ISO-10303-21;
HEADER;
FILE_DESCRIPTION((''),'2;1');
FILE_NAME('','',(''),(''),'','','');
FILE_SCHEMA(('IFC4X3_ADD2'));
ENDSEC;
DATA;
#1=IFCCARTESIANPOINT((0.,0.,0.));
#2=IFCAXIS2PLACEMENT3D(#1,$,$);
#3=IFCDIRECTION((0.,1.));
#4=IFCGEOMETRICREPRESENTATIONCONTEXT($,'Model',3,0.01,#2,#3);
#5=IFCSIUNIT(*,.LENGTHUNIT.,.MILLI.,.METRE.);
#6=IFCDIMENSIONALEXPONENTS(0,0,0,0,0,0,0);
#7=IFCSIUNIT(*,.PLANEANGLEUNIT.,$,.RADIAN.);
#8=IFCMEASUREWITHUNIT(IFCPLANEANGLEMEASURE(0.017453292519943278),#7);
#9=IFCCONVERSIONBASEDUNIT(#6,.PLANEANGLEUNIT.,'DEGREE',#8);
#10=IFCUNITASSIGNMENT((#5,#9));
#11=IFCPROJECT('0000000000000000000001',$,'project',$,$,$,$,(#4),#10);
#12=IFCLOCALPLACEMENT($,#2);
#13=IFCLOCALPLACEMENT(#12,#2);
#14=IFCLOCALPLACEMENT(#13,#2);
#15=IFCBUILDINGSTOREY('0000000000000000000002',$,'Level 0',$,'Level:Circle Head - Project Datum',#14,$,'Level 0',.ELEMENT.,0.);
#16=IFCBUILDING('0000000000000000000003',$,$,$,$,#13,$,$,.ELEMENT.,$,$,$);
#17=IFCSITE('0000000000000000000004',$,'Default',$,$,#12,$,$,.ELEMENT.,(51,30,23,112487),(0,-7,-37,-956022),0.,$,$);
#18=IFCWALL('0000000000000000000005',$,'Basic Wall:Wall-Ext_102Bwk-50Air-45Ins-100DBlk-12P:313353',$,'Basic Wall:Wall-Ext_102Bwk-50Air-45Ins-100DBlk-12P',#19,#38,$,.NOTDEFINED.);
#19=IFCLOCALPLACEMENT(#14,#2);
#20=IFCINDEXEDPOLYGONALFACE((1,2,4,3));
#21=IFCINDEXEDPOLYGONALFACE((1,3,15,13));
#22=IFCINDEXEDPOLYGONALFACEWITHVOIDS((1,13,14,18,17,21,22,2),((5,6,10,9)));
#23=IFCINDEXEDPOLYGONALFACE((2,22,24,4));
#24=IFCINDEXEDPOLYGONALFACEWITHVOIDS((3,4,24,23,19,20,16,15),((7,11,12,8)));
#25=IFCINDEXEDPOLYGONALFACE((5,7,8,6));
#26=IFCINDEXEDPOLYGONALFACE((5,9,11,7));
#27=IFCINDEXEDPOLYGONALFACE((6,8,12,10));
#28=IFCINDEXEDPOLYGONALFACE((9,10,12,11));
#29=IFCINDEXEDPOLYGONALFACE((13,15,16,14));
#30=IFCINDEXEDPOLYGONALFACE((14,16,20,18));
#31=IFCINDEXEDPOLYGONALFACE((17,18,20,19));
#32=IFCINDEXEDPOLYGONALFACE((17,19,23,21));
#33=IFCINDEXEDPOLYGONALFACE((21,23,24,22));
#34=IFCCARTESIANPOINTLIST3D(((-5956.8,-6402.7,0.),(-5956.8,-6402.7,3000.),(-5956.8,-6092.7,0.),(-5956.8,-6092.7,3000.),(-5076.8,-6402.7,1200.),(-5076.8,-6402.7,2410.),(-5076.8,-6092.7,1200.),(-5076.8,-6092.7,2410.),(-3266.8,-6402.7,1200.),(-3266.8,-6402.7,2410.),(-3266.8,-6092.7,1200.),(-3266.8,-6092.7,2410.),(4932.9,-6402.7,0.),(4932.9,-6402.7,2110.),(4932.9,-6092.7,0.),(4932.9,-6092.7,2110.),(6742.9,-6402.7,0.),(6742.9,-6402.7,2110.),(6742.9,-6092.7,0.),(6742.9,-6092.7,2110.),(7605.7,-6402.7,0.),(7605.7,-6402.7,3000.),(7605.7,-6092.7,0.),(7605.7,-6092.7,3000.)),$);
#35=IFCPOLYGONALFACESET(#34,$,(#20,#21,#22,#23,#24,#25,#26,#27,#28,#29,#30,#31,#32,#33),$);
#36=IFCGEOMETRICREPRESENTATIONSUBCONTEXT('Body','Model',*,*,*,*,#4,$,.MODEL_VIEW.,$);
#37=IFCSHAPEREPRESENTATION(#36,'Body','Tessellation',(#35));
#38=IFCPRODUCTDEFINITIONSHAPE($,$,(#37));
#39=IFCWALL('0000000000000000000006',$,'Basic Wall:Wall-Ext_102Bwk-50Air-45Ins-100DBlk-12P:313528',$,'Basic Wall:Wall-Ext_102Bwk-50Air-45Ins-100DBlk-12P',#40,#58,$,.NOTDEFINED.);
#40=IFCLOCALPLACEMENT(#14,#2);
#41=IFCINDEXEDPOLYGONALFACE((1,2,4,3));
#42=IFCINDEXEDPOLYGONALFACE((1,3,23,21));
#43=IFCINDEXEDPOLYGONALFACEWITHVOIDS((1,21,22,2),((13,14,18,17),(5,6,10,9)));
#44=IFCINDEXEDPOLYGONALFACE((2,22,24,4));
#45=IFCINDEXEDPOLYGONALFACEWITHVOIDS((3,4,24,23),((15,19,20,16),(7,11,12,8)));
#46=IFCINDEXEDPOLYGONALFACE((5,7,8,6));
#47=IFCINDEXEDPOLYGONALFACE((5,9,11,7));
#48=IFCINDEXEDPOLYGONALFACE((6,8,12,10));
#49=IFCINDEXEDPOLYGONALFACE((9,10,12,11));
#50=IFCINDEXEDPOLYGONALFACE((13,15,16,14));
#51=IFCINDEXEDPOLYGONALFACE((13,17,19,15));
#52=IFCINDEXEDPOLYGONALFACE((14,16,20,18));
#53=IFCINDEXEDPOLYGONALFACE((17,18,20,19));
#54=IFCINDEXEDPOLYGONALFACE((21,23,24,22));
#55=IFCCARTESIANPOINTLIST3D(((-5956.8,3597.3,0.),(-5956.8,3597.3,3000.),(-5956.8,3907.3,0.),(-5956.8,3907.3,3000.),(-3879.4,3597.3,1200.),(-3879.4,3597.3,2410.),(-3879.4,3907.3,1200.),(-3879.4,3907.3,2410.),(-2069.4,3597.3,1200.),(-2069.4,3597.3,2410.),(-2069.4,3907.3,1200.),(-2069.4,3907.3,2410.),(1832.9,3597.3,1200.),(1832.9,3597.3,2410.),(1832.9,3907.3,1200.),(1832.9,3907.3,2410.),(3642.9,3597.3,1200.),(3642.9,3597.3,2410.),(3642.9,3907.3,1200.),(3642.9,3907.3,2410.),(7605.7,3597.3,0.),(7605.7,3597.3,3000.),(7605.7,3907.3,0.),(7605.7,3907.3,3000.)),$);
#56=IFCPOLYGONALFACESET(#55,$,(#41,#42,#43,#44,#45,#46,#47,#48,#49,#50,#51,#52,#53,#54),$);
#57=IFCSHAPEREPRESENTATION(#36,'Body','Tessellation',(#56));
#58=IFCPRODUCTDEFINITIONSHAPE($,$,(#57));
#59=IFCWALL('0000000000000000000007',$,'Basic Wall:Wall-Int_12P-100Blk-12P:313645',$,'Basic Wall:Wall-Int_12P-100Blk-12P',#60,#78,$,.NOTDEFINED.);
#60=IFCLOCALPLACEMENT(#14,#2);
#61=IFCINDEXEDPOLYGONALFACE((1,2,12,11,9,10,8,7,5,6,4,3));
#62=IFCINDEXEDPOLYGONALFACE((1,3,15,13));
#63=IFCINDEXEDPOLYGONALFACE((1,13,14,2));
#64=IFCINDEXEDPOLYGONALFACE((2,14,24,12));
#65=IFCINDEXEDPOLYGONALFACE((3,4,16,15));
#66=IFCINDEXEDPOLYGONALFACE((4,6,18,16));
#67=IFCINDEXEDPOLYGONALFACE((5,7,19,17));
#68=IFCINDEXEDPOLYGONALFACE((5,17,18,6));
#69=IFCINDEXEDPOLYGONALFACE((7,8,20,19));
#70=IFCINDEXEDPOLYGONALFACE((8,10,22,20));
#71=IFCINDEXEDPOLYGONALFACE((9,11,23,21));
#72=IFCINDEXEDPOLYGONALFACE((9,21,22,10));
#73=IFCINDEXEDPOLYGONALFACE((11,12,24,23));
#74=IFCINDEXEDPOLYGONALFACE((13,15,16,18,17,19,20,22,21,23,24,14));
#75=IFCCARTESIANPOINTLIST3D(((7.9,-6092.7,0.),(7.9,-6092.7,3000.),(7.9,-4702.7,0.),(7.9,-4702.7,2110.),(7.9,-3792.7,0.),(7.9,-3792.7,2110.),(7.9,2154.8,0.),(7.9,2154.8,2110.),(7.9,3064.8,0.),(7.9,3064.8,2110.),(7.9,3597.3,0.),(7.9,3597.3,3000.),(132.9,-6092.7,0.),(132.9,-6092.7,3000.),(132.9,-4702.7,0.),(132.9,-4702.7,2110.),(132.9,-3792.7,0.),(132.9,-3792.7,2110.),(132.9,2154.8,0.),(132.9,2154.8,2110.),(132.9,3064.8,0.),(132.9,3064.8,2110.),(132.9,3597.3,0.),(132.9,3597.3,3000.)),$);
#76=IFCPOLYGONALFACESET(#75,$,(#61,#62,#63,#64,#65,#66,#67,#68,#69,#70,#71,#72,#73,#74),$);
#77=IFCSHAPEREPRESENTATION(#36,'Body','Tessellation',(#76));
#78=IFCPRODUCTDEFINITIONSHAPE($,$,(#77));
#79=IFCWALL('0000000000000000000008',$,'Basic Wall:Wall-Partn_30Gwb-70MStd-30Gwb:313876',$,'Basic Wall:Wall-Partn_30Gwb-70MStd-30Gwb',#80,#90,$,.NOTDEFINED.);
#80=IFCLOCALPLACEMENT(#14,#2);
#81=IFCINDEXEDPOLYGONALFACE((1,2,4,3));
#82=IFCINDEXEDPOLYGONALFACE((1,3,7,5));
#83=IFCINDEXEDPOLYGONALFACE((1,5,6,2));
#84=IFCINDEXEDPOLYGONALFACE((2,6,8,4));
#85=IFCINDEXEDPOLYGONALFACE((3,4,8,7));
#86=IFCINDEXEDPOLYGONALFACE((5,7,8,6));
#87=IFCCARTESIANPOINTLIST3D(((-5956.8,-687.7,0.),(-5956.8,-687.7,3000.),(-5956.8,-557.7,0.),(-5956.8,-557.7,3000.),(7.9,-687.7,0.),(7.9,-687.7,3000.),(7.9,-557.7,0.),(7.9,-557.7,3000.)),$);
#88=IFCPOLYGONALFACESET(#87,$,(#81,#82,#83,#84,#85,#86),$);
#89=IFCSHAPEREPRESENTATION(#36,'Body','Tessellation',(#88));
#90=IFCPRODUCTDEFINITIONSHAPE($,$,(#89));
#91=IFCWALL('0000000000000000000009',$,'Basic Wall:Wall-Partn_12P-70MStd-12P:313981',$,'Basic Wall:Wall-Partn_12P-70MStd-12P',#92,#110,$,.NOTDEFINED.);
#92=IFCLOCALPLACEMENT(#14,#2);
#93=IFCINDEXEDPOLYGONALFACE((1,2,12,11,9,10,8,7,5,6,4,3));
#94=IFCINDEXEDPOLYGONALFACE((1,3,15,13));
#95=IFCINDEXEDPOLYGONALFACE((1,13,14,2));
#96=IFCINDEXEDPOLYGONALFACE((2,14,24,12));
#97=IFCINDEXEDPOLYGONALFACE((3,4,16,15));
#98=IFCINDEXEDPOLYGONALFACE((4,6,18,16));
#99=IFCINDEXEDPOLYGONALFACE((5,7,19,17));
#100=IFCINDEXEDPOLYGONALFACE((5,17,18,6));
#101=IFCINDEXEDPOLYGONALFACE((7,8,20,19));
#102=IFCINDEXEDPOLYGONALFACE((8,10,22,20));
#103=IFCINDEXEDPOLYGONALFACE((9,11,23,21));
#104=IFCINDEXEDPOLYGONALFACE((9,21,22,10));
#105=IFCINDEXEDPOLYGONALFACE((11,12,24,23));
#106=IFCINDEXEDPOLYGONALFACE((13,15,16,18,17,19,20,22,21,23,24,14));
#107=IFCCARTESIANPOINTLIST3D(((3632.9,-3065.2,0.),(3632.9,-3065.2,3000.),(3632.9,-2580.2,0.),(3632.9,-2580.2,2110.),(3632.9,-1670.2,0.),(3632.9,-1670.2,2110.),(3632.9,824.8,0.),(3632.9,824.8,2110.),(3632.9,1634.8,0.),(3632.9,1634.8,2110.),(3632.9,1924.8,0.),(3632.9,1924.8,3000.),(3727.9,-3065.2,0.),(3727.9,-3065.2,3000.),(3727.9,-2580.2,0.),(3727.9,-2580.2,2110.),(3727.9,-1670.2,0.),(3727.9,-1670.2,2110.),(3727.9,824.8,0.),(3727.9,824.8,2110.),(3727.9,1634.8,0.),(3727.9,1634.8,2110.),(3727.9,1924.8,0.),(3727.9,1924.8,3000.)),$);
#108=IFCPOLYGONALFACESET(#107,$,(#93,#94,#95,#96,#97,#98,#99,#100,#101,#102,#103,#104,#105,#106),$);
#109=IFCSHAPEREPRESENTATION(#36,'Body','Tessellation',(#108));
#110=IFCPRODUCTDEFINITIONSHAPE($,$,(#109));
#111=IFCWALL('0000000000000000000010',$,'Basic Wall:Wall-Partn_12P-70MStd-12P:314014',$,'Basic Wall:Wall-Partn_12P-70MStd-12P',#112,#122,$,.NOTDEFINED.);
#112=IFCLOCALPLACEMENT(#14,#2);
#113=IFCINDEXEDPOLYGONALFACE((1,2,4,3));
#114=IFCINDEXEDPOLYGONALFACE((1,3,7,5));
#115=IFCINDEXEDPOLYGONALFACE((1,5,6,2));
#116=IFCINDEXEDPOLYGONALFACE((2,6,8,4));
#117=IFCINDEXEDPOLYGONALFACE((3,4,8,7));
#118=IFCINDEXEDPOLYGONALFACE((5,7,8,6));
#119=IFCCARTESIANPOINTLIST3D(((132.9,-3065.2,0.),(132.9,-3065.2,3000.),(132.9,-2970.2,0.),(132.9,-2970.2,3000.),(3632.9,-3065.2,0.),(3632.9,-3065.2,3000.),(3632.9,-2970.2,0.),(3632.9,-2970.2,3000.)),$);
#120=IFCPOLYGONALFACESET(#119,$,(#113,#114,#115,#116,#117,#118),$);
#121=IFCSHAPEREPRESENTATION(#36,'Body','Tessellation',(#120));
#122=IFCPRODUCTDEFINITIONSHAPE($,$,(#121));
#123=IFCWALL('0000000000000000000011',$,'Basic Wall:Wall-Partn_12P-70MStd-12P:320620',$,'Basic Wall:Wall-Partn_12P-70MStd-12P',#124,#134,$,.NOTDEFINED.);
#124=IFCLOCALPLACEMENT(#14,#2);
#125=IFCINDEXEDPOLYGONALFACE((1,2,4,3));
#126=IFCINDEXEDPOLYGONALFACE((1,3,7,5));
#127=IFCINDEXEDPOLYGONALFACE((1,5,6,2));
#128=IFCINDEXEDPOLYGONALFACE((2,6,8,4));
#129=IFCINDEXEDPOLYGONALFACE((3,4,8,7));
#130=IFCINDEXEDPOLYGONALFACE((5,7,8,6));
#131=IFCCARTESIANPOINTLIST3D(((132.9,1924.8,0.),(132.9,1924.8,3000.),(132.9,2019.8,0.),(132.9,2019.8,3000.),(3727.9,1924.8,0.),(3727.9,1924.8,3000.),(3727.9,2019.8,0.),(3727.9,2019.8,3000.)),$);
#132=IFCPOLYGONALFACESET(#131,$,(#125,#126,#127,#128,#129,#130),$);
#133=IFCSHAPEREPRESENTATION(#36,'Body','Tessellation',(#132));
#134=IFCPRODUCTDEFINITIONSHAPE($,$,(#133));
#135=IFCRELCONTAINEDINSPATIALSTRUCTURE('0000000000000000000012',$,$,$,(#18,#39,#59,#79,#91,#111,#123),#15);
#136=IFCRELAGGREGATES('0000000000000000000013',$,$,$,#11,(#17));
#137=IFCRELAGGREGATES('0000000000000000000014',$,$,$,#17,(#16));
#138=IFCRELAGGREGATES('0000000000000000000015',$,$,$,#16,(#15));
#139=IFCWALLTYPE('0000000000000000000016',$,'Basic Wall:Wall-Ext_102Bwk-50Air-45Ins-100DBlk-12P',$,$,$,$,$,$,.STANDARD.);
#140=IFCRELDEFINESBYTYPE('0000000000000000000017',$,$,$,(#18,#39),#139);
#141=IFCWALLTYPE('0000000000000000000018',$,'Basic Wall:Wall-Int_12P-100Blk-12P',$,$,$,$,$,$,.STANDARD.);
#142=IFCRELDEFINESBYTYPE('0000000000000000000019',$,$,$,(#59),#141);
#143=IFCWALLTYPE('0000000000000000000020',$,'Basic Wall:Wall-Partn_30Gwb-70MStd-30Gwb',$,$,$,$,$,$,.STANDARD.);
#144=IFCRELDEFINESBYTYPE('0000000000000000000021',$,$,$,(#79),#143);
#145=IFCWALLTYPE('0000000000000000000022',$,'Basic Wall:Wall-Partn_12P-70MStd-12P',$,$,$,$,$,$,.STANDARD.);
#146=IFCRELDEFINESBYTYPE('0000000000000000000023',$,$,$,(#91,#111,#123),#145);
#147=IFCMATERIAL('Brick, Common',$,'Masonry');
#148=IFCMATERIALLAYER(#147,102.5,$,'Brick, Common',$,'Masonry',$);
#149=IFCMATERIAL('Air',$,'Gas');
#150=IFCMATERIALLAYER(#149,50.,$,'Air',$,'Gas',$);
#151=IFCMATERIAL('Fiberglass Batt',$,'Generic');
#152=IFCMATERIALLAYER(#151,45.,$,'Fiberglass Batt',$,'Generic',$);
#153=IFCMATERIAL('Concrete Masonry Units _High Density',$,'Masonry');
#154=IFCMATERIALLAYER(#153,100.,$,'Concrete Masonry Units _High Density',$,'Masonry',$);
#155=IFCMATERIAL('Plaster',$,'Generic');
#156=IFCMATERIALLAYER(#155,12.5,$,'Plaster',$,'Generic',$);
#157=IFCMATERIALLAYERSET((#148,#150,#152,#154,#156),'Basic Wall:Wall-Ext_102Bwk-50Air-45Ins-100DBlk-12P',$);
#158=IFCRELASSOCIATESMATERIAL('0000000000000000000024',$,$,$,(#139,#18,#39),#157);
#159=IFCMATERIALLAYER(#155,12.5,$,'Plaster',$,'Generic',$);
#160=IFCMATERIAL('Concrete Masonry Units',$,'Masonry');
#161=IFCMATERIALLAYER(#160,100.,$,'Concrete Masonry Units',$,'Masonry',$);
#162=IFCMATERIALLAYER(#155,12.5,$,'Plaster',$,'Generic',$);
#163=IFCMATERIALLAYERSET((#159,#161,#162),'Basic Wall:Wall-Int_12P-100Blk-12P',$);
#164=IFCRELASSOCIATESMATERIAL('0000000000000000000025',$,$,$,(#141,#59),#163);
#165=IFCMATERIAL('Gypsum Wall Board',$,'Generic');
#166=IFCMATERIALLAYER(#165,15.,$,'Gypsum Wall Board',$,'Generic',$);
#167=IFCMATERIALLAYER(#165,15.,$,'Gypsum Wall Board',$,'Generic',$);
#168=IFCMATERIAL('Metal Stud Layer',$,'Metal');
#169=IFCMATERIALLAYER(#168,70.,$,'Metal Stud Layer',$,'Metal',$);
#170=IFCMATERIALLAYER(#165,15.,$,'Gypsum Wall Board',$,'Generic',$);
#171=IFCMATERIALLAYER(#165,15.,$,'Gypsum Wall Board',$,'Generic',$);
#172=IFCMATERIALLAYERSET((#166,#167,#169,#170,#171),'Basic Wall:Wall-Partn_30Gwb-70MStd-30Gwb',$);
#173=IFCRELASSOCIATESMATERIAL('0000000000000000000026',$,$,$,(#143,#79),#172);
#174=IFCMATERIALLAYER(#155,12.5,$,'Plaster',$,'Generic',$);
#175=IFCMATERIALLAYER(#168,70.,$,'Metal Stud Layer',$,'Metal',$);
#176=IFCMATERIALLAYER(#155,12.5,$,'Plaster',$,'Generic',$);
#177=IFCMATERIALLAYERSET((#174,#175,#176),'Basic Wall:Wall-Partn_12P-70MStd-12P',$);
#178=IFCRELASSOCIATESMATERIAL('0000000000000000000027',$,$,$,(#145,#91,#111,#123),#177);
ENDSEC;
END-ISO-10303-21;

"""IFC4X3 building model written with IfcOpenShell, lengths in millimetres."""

from ifc_helpers import new_model, entity, si_unit, converted_unit, direction, frame, frame_2d, origin, place, context, subcontext, project, spatial, rectangle, extrude, material, layer, layer_set, type_object, element, save


model = new_model("IFC4X3")

# Units and contexts
model_context = context("Model", 3, precision=0.01, world=origin(), true_north=direction((0.0, 1.0)))
body_context = subcontext(model_context, "Body", "Model", "MODEL_VIEW")
ifc_project = project(units=[si_unit("LENGTHUNIT", "METRE", prefix="MILLI"), converted_unit("PLANEANGLEUNIT", "DEGREE", entity("IfcPlaneAngleMeasure", 0.017453292519943278), si_unit("PLANEANGLEUNIT", "RADIAN"), dimensions=[0, 0, 0, 0, 0, 0, 0])], contexts=[model_context])

# Site, building, storey
site_placement = place(None, origin())
site = spatial("IfcSite", under=ifc_project, at=site_placement, Name="Default", CompositionType="ELEMENT", RefLatitude=(51, 30, 23, 112487), RefLongitude=(0, -7, -37, -956022), RefElevation=0.0)
building_placement = place(site_placement, origin())
building = spatial("IfcBuilding", under=site, at=building_placement, CompositionType="ELEMENT")
storey_placement = place(building_placement, origin())
storey = spatial("IfcBuildingStorey", under=building, at=storey_placement, Name="Level 0", ObjectType="Level:Circle Head - Project Datum", LongName="Level 0", CompositionType="ELEMENT", Elevation=0.0)

# Shared definitions
ifc_material_1 = material(Name="Air", Category="Gas")

# Walls, openings
ifc_material_2 = material(Name="Brick, Common", Category="Masonry")
ifc_layer_1 = layer(ifc_material_2, 102.5, Name="Brick, Common", Category="Masonry")
ifc_layer_2 = layer(ifc_material_1, 50.0, Name="Air", Category="Gas")
ifc_material_3 = material(Name="Fiberglass Batt", Category="Generic")
ifc_layer_3 = layer(ifc_material_3, 45.0, Name="Fiberglass Batt", Category="Generic")
ifc_material_4 = material(Name="Concrete Masonry Units _High Density", Category="Masonry")
ifc_layer_4 = layer(ifc_material_4, 100.0, Name="Concrete Masonry Units _High Density", Category="Masonry")
ifc_material_5 = material(Name="Plaster", Category="Generic")
ifc_layer_5 = layer(ifc_material_5, 12.5, Name="Plaster", Category="Generic")
ifc_layer_set_1 = layer_set([ifc_layer_1, ifc_layer_2, ifc_layer_3, ifc_layer_4, ifc_layer_5], Name="Basic Wall:Wall-Ext_102Bwk-50Air-45Ins-100DBlk-12P")
wall_type_1 = type_object("IfcWallType", Name="Basic Wall:Wall-Ext_102Bwk-50Air-45Ins-100DBlk-12P", PredefinedType="STANDARD", material=ifc_layer_set_1)
wall_1_placement = place(storey_placement, frame((-5956.8, -6247.7, 0.0)))
wall_1 = element("IfcWall", 1, at=wall_1_placement, inside=storey, type_object=wall_type_1, material=ifc_layer_set_1, Name="Basic Wall:Wall-Ext_102Bwk-50Air-45Ins-100DBlk-12P:313353", ObjectType="Basic Wall:Wall-Ext_102Bwk-50Air-45Ins-100DBlk-12P", PredefinedType="NOTDEFINED", context=body_context, shape_type="SweptSolid", body=[
    extrude(rectangle(XDim=13562.5, YDim=310.0, at=frame_2d((6781.3, 0.0), x_axis=(1.0, 0.0))), origin(), (0.0, 0.0, 1.0), 3000.0),
])
opening_1_placement = place(wall_1_placement, frame((5956.8, 6247.7, 0.0)))
element("IfcOpeningElement", 2, at=opening_1_placement, cuts=wall_1, PredefinedType="OPENING", context=body_context, shape_type="SweptSolid", body=[
    extrude(rectangle(XDim=2110.0, YDim=1810.0, at=frame_2d((0.0, 0.0), x_axis=(0.0, 1.0))), frame((5837.9, -7926.7, 1055.0), z_axis=(0.0, 1.0, 0.0), x_axis=(1.0, 0.0, 0.0)), (0.0, 0.0, 1.0), 3048.0),
])
opening_2_placement = place(wall_1_placement, frame((2690.0, 155.0, 1200.0)))
element("IfcOpeningElement", 3, at=opening_2_placement, cuts=wall_1, PredefinedType="OPENING", context=body_context, shape_type="SweptSolid", body=[
    extrude(rectangle(XDim=1210.0, YDim=1810.0, at=frame_2d((605.0, 905.0), x_axis=(-1.0, 0.0))), frame((0.0, 0.0, 0.0), z_axis=(0.0, -1.0, 0.0), x_axis=(0.0, 0.0, 1.0)), (0.0, 0.0, 1.0), 310.0),
])
wall_2_placement = place(storey_placement, frame((7605.7, 3752.3, 0.0), z_axis=(0.0, 0.0, 1.0), x_axis=(-1.0, 0.0, 0.0)))
wall_2 = element("IfcWall", 4, at=wall_2_placement, inside=storey, type_object=wall_type_1, material=ifc_layer_set_1, Name="Basic Wall:Wall-Ext_102Bwk-50Air-45Ins-100DBlk-12P:313528", ObjectType="Basic Wall:Wall-Ext_102Bwk-50Air-45Ins-100DBlk-12P", PredefinedType="NOTDEFINED", context=body_context, shape_type="SweptSolid", body=[
    extrude(rectangle(XDim=13562.5, YDim=310.0, at=frame_2d((6781.3, 0.0), x_axis=(-1.0, 0.0))), origin(), (0.0, 0.0, 1.0), 3000.0),
])
opening_3_placement = place(wall_2_placement, frame((5772.8, 155.0, 1200.0)))
element("IfcOpeningElement", 5, at=opening_3_placement, cuts=wall_2, PredefinedType="OPENING", context=body_context, shape_type="SweptSolid", body=[
    extrude(rectangle(XDim=1210.0, YDim=1810.0, at=frame_2d((605.0, 905.0), x_axis=(-1.0, 0.0))), frame((0.0, 0.0, 0.0), z_axis=(0.0, -1.0, 0.0), x_axis=(0.0, 0.0, 1.0)), (0.0, 0.0, 1.0), 310.0),
])
opening_4_placement = place(wall_2_placement, frame((11485.1, 155.0, 1200.0)))
element("IfcOpeningElement", 6, at=opening_4_placement, cuts=wall_2, PredefinedType="OPENING", context=body_context, shape_type="SweptSolid", body=[
    extrude(rectangle(XDim=1210.0, YDim=1810.0, at=frame_2d((605.0, 905.0), x_axis=(-1.0, 0.0))), frame((0.0, 0.0, 0.0), z_axis=(0.0, -1.0, 0.0), x_axis=(0.0, 0.0, 1.0)), (0.0, 0.0, 1.0), 310.0),
])
ifc_layer_6 = layer(ifc_material_5, 12.5, Name="Plaster", Category="Generic")
ifc_material_6 = material(Name="Concrete Masonry Units", Category="Masonry")
ifc_layer_7 = layer(ifc_material_6, 100.0, Name="Concrete Masonry Units", Category="Masonry")
ifc_layer_8 = layer(ifc_material_5, 12.5, Name="Plaster", Category="Generic")
ifc_layer_set_2 = layer_set([ifc_layer_6, ifc_layer_7, ifc_layer_8], Name="Basic Wall:Wall-Int_12P-100Blk-12P")
wall_type_2 = type_object("IfcWallType", Name="Basic Wall:Wall-Int_12P-100Blk-12P", PredefinedType="STANDARD", material=ifc_layer_set_2)
wall_3_placement = place(storey_placement, frame((70.4, 3597.3, 0.0), z_axis=(0.0, 0.0, 1.0), x_axis=(0.0, -1.0, 0.0)))
wall_3 = element("IfcWall", 7, at=wall_3_placement, inside=storey, type_object=wall_type_2, material=ifc_layer_set_2, Name="Basic Wall:Wall-Int_12P-100Blk-12P:313645", ObjectType="Basic Wall:Wall-Int_12P-100Blk-12P", PredefinedType="NOTDEFINED", context=body_context, shape_type="SweptSolid", body=[
    extrude(rectangle(XDim=9690.0, YDim=125.0, at=frame_2d((4845.0, 0.0), x_axis=(1.0, 0.0))), origin(), (0.0, 0.0, 1.0), 3000.0),
])
opening_5_placement = place(wall_3_placement, frame((8300.0, 62.5, 0.0)))
element("IfcOpeningElement", 8, at=opening_5_placement, cuts=wall_3, PredefinedType="OPENING", context=body_context, shape_type="SweptSolid", body=[
    extrude(rectangle(XDim=2110.0, YDim=910.0, at=frame_2d((1055.0, 455.0), x_axis=(1.0, 0.0))), frame((0.0, 0.0, 0.0), z_axis=(0.0, -1.0, 0.0), x_axis=(0.0, 0.0, 1.0)), (0.0, 0.0, 1.0), 125.0),
])
opening_6_placement = place(wall_3_placement, frame((1442.5, 62.5, 0.0)))
element("IfcOpeningElement", 9, at=opening_6_placement, cuts=wall_3, PredefinedType="OPENING", context=body_context, shape_type="SweptSolid", body=[
    extrude(rectangle(XDim=2110.0, YDim=910.0, at=frame_2d((1055.0, 455.0), x_axis=(1.0, 0.0))), frame((0.0, 0.0, 0.0), z_axis=(0.0, -1.0, 0.0), x_axis=(0.0, 0.0, 1.0)), (0.0, 0.0, 1.0), 125.0),
])

# Wall
ifc_material_7 = material(Name="Gypsum Wall Board", Category="Generic")
ifc_layer_9 = layer(ifc_material_7, 15.0, Name="Gypsum Wall Board", Category="Generic")
ifc_layer_10 = layer(ifc_material_7, 15.0, Name="Gypsum Wall Board", Category="Generic")
ifc_material_8 = material(Name="Metal Stud Layer", Category="Metal")
ifc_layer_11 = layer(ifc_material_8, 70.0, Name="Metal Stud Layer", Category="Metal")
ifc_layer_12 = layer(ifc_material_7, 15.0, Name="Gypsum Wall Board", Category="Generic")
ifc_layer_13 = layer(ifc_material_7, 15.0, Name="Gypsum Wall Board", Category="Generic")
ifc_layer_set_3 = layer_set([ifc_layer_9, ifc_layer_10, ifc_layer_11, ifc_layer_12, ifc_layer_13], Name="Basic Wall:Wall-Partn_30Gwb-70MStd-30Gwb")
wall_type_3 = type_object("IfcWallType", Name="Basic Wall:Wall-Partn_30Gwb-70MStd-30Gwb", PredefinedType="STANDARD", material=ifc_layer_set_3)
wall_4_placement = place(storey_placement, frame((7.9, -622.7, 0.0), z_axis=(0.0, 0.0, 1.0), x_axis=(-1.0, 0.0, 0.0)))
element("IfcWall", 10, at=wall_4_placement, inside=storey, type_object=wall_type_3, material=ifc_layer_set_3, Name="Basic Wall:Wall-Partn_30Gwb-70MStd-30Gwb:313876", ObjectType="Basic Wall:Wall-Partn_30Gwb-70MStd-30Gwb", PredefinedType="NOTDEFINED", context=body_context, shape_type="SweptSolid", body=[
    extrude(rectangle(XDim=5964.7, YDim=130.0, at=frame_2d((2982.4, 0.0), x_axis=(-1.0, 0.0))), origin(), (0.0, 0.0, 1.0), 3000.0),
])

# Wall, openings
ifc_layer_14 = layer(ifc_material_5, 12.5, Name="Plaster", Category="Generic")
ifc_layer_15 = layer(ifc_material_8, 70.0, Name="Metal Stud Layer", Category="Metal")
ifc_layer_16 = layer(ifc_material_5, 12.5, Name="Plaster", Category="Generic")
ifc_layer_set_4 = layer_set([ifc_layer_14, ifc_layer_15, ifc_layer_16], Name="Basic Wall:Wall-Partn_12P-70MStd-12P")
wall_type_4 = type_object("IfcWallType", Name="Basic Wall:Wall-Partn_12P-70MStd-12P", PredefinedType="STANDARD", material=ifc_layer_set_4)
wall_5_placement = place(storey_placement, frame((3680.4, 1924.8, 0.0), z_axis=(0.0, 0.0, 1.0), x_axis=(0.0, -1.0, 0.0)))
wall_5 = element("IfcWall", 11, at=wall_5_placement, inside=storey, type_object=wall_type_4, material=ifc_layer_set_4, Name="Basic Wall:Wall-Partn_12P-70MStd-12P:313981", ObjectType="Basic Wall:Wall-Partn_12P-70MStd-12P", PredefinedType="NOTDEFINED", context=body_context, shape_type="SweptSolid", body=[
    extrude(rectangle(XDim=4990.0, YDim=95.0, at=frame_2d((2495.0, 0.0), x_axis=(1.0, 0.0))), origin(), (0.0, 0.0, 1.0), 3000.0),
])
opening_7_placement = place(wall_5_placement, frame((4505.0, 47.5, 0.0)))
element("IfcOpeningElement", 12, at=opening_7_placement, cuts=wall_5, PredefinedType="OPENING", context=body_context, shape_type="SweptSolid", body=[
    extrude(rectangle(XDim=2110.0, YDim=910.0, at=frame_2d((1055.0, 455.0), x_axis=(1.0, 0.0))), frame((0.0, 0.0, 0.0), z_axis=(0.0, -1.0, 0.0), x_axis=(0.0, 0.0, 1.0)), (0.0, 0.0, 1.0), 95.0),
])
opening_8_placement = place(wall_5_placement, frame((1100.0, 47.5, 0.0)))
element("IfcOpeningElement", 13, at=opening_8_placement, cuts=wall_5, PredefinedType="OPENING", context=body_context, shape_type="SweptSolid", body=[
    extrude(rectangle(XDim=2110.0, YDim=810.0, at=frame_2d((1055.0, 405.0), x_axis=(1.0, 0.0))), frame((0.0, 0.0, 0.0), z_axis=(0.0, -1.0, 0.0), x_axis=(0.0, 0.0, 1.0)), (0.0, 0.0, 1.0), 95.0),
])

# Walls
wall_6_placement = place(storey_placement, frame((3632.9, -3017.7, 0.0), z_axis=(0.0, 0.0, 1.0), x_axis=(-1.0, 0.0, 0.0)))
element("IfcWall", 14, at=wall_6_placement, inside=storey, type_object=wall_type_4, material=ifc_layer_set_4, Name="Basic Wall:Wall-Partn_12P-70MStd-12P:314014", ObjectType="Basic Wall:Wall-Partn_12P-70MStd-12P", PredefinedType="NOTDEFINED", context=body_context, shape_type="SweptSolid", body=[
    extrude(rectangle(XDim=3500.0, YDim=95.0, at=frame_2d((1750.0, 0.0), x_axis=(-1.0, 0.0))), origin(), (0.0, 0.0, 1.0), 3000.0),
])
wall_7_placement = place(storey_placement, frame((3727.9, 1972.3, 0.0), z_axis=(0.0, 0.0, 1.0), x_axis=(-1.0, 0.0, 0.0)))
element("IfcWall", 15, at=wall_7_placement, inside=storey, type_object=wall_type_4, material=ifc_layer_set_4, Name="Basic Wall:Wall-Partn_12P-70MStd-12P:320620", ObjectType="Basic Wall:Wall-Partn_12P-70MStd-12P", PredefinedType="NOTDEFINED", context=body_context, shape_type="SweptSolid", body=[
    extrude(rectangle(XDim=3595.0, YDim=95.0, at=frame_2d((1797.5, 0.0), x_axis=(-1.0, 0.0))), origin(), (0.0, 0.0, 1.0), 3000.0),
])

save(model, "model.ifc")
